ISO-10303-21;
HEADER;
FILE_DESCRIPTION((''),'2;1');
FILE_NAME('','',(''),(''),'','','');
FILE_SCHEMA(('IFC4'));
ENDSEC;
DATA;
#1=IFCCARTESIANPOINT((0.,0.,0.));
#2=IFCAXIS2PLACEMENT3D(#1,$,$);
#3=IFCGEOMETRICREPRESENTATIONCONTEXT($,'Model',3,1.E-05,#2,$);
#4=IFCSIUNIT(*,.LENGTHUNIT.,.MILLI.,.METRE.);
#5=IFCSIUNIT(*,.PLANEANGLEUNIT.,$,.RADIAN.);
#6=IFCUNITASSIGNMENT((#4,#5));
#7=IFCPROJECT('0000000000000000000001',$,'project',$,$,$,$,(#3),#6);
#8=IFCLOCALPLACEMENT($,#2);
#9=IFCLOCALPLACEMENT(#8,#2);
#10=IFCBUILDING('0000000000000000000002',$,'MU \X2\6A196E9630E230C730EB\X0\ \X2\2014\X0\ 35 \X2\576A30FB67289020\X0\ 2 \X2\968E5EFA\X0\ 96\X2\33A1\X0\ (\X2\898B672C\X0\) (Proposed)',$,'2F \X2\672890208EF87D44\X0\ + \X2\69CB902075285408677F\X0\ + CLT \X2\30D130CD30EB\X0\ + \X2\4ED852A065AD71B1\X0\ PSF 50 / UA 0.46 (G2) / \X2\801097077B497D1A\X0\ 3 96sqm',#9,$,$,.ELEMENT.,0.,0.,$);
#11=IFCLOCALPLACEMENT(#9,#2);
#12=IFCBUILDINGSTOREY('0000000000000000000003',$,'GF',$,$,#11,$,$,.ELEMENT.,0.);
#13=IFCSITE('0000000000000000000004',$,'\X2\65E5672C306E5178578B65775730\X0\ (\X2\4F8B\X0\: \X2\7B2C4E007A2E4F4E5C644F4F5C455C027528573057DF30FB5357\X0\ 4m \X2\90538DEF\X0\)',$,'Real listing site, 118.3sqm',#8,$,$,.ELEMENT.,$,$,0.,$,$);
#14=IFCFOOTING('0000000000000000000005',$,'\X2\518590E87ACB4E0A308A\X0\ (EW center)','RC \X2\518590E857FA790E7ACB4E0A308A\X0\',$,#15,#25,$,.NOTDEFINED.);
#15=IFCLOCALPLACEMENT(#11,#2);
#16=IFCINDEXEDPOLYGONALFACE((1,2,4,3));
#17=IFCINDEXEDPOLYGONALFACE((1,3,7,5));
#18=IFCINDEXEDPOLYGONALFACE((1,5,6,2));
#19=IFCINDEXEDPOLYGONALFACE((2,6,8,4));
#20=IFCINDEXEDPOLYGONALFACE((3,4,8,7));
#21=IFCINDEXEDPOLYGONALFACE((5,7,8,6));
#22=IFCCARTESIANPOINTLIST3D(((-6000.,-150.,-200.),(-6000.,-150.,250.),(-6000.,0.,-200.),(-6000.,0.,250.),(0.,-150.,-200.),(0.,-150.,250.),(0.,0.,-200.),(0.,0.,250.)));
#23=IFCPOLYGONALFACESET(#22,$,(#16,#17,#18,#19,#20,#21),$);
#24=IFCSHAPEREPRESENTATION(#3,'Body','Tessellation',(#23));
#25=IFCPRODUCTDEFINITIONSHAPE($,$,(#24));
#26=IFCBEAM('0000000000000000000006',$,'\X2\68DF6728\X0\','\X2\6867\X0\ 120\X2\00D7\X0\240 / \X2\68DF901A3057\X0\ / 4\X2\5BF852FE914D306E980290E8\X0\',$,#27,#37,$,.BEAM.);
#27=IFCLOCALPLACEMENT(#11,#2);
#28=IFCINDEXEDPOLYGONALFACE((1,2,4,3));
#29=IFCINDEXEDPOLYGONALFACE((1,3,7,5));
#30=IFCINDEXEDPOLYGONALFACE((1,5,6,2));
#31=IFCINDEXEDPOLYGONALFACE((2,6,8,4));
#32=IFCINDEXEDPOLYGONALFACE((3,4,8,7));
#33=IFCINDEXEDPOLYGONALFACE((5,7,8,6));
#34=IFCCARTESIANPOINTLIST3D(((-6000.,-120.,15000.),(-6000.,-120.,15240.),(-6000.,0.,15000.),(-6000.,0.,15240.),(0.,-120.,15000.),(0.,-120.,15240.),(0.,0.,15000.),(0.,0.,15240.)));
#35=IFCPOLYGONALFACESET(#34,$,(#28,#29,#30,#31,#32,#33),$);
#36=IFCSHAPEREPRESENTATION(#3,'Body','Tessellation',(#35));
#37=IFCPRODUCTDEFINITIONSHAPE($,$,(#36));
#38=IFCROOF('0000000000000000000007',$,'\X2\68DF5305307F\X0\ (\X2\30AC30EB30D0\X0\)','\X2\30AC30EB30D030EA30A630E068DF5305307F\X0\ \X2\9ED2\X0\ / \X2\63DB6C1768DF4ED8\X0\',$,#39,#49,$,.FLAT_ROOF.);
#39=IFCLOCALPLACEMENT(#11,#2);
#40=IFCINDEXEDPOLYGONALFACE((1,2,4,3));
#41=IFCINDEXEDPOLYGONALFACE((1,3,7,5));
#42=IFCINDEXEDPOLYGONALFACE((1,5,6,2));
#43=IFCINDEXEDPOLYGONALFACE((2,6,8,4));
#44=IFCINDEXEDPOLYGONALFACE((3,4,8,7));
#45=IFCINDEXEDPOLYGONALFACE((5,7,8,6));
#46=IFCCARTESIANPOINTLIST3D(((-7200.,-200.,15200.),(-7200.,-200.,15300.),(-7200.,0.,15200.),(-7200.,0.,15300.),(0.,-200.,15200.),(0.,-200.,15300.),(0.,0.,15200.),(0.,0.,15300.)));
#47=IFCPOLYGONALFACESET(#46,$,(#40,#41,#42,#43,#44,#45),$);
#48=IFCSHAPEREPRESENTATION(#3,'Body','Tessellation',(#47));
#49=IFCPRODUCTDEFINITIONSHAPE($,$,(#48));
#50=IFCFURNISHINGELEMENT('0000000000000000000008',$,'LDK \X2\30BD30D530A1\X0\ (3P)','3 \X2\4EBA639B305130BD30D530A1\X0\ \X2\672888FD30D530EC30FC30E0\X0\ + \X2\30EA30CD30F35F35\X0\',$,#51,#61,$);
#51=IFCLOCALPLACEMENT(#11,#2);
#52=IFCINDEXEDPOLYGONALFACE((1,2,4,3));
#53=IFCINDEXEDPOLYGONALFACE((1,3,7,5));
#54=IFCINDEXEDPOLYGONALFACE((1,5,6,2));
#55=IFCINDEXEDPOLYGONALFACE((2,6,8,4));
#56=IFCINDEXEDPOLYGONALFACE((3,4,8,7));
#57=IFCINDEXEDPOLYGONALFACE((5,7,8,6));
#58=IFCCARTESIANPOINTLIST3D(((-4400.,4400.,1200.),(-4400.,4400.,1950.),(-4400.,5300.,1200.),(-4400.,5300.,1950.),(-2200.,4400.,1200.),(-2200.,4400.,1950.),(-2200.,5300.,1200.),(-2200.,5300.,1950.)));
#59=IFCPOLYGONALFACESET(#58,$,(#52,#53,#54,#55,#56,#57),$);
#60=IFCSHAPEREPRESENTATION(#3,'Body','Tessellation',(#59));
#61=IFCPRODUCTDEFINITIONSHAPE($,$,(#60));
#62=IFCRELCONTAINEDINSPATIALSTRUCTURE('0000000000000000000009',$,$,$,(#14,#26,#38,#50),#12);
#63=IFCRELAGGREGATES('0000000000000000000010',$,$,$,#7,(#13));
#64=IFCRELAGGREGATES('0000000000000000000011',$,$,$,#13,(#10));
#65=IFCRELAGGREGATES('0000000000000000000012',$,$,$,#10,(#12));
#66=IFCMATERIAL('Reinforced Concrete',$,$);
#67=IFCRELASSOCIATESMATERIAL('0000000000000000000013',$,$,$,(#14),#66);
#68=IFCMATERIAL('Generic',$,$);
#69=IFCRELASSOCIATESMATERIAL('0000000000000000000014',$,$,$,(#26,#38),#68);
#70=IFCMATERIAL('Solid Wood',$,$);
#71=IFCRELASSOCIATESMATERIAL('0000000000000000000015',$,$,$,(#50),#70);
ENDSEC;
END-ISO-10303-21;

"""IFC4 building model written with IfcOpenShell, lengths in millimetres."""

from ifc_helpers import new_model, si_unit, frame, frame_2d, origin, place, context, project, spatial, rectangle, extrude, material, element, save


model = new_model("IFC4")

# Units and contexts
model_context = context("Model", 3, precision=1e-05, world=origin())
ifc_project = project(units=[si_unit("LENGTHUNIT", "METRE", prefix="MILLI"), si_unit("PLANEANGLEUNIT", "RADIAN")], contexts=[model_context])

# Site, building, storey
site_placement = place(None, origin())
site = spatial("IfcSite", under=ifc_project, at=site_placement, Name="日本の典型敷地 (例: 第一種低層住居専用地域・南 4m 道路)", ObjectType="Real listing site, 118.3sqm", CompositionType="ELEMENT", RefElevation=0.0)
building_placement = place(site_placement, origin())
building = spatial("IfcBuilding", under=site, at=building_placement, Name="MU 標準モデル — 35 坪・木造 2 階建 96㎡ (見本) (Proposed)", ObjectType="2F 木造軸組 + 構造用合板 + CLT パネル + 付加断熱 PSF 50 / UA 0.46 (G2) / 耐震等級 3 96sqm", CompositionType="ELEMENT", ElevationOfRefHeight=0.0, ElevationOfTerrain=0.0)
storey_placement = place(building_placement, origin())
storey = spatial("IfcBuildingStorey", under=building, at=storey_placement, Name="GF", CompositionType="ELEMENT", Elevation=0.0)

# Footing
ifc_material_1 = material(Name="Reinforced Concrete")
footing_placement = place(storey_placement, frame((-3000.0, -75.0, -100.0)))
element("IfcFooting", 1, at=footing_placement, inside=storey, material=ifc_material_1, Name="内部立上り (EW center)", Description="RC 内部基礎立上り", PredefinedType="NOTDEFINED", context=model_context, shape_type="SweptSolid", body=[
    extrude(rectangle(XDim=6000.0, YDim=150.0, at=frame_2d((3000.0, 75.0))), frame((-3000.0, -75.0, -100.0)), (0.0, 0.0, 1.0), 450.0),
])

# Shared definitions
ifc_material_2 = material(Name="Generic")

# Beam
beam_1_placement = place(storey_placement, frame((-3000.0, -60.0, 7500.0)))
element("IfcBeam", 2, at=beam_1_placement, inside=storey, material=ifc_material_2, Name="棟木", Description="桧 120×240 / 棟通し / 4寸勾配の頂部", PredefinedType="BEAM", context=model_context, shape_type="SweptSolid", body=[
    extrude(rectangle(XDim=6000.0, YDim=120.0, at=frame_2d((3000.0, 60.0))), frame((-3000.0, -60.0, 7500.0)), (0.0, 0.0, 1.0), 240.0),
])

# Roof
roof_1_placement = place(storey_placement, frame((-3600.0, -100.0, 7600.0)))
element("IfcRoof", 3, at=roof_1_placement, inside=storey, material=ifc_material_2, Name="棟包み (ガルバ)", Description="ガルバリウム棟包み 黒 / 換気棟付", PredefinedType="FLAT_ROOF", context=model_context, shape_type="SweptSolid", body=[
    extrude(rectangle(XDim=7200.0, YDim=200.0, at=frame_2d((3600.0, 100.0))), frame((-3600.0, -100.0, 7600.0)), (0.0, 0.0, 1.0), 100.0),
])

# Furnishing element
ifc_material_3 = material(Name="Solid Wood")
furnishing_1_placement = place(storey_placement, frame((-2200.0, 2200.0, 600.0)))
element("IfcFurnishingElement", 4, at=furnishing_1_placement, inside=storey, material=ifc_material_3, Name="LDK ソファ (3P)", Description="3 人掛けソファ 木製フレーム + リネン張", context=model_context, shape_type="SweptSolid", body=[
    extrude(rectangle(XDim=2200.0, YDim=900.0, at=frame_2d((1100.0, 450.0))), frame((-2200.0, 2200.0, 600.0)), (0.0, 0.0, 1.0), 750.0),
])

save(model, "model.ifc")
